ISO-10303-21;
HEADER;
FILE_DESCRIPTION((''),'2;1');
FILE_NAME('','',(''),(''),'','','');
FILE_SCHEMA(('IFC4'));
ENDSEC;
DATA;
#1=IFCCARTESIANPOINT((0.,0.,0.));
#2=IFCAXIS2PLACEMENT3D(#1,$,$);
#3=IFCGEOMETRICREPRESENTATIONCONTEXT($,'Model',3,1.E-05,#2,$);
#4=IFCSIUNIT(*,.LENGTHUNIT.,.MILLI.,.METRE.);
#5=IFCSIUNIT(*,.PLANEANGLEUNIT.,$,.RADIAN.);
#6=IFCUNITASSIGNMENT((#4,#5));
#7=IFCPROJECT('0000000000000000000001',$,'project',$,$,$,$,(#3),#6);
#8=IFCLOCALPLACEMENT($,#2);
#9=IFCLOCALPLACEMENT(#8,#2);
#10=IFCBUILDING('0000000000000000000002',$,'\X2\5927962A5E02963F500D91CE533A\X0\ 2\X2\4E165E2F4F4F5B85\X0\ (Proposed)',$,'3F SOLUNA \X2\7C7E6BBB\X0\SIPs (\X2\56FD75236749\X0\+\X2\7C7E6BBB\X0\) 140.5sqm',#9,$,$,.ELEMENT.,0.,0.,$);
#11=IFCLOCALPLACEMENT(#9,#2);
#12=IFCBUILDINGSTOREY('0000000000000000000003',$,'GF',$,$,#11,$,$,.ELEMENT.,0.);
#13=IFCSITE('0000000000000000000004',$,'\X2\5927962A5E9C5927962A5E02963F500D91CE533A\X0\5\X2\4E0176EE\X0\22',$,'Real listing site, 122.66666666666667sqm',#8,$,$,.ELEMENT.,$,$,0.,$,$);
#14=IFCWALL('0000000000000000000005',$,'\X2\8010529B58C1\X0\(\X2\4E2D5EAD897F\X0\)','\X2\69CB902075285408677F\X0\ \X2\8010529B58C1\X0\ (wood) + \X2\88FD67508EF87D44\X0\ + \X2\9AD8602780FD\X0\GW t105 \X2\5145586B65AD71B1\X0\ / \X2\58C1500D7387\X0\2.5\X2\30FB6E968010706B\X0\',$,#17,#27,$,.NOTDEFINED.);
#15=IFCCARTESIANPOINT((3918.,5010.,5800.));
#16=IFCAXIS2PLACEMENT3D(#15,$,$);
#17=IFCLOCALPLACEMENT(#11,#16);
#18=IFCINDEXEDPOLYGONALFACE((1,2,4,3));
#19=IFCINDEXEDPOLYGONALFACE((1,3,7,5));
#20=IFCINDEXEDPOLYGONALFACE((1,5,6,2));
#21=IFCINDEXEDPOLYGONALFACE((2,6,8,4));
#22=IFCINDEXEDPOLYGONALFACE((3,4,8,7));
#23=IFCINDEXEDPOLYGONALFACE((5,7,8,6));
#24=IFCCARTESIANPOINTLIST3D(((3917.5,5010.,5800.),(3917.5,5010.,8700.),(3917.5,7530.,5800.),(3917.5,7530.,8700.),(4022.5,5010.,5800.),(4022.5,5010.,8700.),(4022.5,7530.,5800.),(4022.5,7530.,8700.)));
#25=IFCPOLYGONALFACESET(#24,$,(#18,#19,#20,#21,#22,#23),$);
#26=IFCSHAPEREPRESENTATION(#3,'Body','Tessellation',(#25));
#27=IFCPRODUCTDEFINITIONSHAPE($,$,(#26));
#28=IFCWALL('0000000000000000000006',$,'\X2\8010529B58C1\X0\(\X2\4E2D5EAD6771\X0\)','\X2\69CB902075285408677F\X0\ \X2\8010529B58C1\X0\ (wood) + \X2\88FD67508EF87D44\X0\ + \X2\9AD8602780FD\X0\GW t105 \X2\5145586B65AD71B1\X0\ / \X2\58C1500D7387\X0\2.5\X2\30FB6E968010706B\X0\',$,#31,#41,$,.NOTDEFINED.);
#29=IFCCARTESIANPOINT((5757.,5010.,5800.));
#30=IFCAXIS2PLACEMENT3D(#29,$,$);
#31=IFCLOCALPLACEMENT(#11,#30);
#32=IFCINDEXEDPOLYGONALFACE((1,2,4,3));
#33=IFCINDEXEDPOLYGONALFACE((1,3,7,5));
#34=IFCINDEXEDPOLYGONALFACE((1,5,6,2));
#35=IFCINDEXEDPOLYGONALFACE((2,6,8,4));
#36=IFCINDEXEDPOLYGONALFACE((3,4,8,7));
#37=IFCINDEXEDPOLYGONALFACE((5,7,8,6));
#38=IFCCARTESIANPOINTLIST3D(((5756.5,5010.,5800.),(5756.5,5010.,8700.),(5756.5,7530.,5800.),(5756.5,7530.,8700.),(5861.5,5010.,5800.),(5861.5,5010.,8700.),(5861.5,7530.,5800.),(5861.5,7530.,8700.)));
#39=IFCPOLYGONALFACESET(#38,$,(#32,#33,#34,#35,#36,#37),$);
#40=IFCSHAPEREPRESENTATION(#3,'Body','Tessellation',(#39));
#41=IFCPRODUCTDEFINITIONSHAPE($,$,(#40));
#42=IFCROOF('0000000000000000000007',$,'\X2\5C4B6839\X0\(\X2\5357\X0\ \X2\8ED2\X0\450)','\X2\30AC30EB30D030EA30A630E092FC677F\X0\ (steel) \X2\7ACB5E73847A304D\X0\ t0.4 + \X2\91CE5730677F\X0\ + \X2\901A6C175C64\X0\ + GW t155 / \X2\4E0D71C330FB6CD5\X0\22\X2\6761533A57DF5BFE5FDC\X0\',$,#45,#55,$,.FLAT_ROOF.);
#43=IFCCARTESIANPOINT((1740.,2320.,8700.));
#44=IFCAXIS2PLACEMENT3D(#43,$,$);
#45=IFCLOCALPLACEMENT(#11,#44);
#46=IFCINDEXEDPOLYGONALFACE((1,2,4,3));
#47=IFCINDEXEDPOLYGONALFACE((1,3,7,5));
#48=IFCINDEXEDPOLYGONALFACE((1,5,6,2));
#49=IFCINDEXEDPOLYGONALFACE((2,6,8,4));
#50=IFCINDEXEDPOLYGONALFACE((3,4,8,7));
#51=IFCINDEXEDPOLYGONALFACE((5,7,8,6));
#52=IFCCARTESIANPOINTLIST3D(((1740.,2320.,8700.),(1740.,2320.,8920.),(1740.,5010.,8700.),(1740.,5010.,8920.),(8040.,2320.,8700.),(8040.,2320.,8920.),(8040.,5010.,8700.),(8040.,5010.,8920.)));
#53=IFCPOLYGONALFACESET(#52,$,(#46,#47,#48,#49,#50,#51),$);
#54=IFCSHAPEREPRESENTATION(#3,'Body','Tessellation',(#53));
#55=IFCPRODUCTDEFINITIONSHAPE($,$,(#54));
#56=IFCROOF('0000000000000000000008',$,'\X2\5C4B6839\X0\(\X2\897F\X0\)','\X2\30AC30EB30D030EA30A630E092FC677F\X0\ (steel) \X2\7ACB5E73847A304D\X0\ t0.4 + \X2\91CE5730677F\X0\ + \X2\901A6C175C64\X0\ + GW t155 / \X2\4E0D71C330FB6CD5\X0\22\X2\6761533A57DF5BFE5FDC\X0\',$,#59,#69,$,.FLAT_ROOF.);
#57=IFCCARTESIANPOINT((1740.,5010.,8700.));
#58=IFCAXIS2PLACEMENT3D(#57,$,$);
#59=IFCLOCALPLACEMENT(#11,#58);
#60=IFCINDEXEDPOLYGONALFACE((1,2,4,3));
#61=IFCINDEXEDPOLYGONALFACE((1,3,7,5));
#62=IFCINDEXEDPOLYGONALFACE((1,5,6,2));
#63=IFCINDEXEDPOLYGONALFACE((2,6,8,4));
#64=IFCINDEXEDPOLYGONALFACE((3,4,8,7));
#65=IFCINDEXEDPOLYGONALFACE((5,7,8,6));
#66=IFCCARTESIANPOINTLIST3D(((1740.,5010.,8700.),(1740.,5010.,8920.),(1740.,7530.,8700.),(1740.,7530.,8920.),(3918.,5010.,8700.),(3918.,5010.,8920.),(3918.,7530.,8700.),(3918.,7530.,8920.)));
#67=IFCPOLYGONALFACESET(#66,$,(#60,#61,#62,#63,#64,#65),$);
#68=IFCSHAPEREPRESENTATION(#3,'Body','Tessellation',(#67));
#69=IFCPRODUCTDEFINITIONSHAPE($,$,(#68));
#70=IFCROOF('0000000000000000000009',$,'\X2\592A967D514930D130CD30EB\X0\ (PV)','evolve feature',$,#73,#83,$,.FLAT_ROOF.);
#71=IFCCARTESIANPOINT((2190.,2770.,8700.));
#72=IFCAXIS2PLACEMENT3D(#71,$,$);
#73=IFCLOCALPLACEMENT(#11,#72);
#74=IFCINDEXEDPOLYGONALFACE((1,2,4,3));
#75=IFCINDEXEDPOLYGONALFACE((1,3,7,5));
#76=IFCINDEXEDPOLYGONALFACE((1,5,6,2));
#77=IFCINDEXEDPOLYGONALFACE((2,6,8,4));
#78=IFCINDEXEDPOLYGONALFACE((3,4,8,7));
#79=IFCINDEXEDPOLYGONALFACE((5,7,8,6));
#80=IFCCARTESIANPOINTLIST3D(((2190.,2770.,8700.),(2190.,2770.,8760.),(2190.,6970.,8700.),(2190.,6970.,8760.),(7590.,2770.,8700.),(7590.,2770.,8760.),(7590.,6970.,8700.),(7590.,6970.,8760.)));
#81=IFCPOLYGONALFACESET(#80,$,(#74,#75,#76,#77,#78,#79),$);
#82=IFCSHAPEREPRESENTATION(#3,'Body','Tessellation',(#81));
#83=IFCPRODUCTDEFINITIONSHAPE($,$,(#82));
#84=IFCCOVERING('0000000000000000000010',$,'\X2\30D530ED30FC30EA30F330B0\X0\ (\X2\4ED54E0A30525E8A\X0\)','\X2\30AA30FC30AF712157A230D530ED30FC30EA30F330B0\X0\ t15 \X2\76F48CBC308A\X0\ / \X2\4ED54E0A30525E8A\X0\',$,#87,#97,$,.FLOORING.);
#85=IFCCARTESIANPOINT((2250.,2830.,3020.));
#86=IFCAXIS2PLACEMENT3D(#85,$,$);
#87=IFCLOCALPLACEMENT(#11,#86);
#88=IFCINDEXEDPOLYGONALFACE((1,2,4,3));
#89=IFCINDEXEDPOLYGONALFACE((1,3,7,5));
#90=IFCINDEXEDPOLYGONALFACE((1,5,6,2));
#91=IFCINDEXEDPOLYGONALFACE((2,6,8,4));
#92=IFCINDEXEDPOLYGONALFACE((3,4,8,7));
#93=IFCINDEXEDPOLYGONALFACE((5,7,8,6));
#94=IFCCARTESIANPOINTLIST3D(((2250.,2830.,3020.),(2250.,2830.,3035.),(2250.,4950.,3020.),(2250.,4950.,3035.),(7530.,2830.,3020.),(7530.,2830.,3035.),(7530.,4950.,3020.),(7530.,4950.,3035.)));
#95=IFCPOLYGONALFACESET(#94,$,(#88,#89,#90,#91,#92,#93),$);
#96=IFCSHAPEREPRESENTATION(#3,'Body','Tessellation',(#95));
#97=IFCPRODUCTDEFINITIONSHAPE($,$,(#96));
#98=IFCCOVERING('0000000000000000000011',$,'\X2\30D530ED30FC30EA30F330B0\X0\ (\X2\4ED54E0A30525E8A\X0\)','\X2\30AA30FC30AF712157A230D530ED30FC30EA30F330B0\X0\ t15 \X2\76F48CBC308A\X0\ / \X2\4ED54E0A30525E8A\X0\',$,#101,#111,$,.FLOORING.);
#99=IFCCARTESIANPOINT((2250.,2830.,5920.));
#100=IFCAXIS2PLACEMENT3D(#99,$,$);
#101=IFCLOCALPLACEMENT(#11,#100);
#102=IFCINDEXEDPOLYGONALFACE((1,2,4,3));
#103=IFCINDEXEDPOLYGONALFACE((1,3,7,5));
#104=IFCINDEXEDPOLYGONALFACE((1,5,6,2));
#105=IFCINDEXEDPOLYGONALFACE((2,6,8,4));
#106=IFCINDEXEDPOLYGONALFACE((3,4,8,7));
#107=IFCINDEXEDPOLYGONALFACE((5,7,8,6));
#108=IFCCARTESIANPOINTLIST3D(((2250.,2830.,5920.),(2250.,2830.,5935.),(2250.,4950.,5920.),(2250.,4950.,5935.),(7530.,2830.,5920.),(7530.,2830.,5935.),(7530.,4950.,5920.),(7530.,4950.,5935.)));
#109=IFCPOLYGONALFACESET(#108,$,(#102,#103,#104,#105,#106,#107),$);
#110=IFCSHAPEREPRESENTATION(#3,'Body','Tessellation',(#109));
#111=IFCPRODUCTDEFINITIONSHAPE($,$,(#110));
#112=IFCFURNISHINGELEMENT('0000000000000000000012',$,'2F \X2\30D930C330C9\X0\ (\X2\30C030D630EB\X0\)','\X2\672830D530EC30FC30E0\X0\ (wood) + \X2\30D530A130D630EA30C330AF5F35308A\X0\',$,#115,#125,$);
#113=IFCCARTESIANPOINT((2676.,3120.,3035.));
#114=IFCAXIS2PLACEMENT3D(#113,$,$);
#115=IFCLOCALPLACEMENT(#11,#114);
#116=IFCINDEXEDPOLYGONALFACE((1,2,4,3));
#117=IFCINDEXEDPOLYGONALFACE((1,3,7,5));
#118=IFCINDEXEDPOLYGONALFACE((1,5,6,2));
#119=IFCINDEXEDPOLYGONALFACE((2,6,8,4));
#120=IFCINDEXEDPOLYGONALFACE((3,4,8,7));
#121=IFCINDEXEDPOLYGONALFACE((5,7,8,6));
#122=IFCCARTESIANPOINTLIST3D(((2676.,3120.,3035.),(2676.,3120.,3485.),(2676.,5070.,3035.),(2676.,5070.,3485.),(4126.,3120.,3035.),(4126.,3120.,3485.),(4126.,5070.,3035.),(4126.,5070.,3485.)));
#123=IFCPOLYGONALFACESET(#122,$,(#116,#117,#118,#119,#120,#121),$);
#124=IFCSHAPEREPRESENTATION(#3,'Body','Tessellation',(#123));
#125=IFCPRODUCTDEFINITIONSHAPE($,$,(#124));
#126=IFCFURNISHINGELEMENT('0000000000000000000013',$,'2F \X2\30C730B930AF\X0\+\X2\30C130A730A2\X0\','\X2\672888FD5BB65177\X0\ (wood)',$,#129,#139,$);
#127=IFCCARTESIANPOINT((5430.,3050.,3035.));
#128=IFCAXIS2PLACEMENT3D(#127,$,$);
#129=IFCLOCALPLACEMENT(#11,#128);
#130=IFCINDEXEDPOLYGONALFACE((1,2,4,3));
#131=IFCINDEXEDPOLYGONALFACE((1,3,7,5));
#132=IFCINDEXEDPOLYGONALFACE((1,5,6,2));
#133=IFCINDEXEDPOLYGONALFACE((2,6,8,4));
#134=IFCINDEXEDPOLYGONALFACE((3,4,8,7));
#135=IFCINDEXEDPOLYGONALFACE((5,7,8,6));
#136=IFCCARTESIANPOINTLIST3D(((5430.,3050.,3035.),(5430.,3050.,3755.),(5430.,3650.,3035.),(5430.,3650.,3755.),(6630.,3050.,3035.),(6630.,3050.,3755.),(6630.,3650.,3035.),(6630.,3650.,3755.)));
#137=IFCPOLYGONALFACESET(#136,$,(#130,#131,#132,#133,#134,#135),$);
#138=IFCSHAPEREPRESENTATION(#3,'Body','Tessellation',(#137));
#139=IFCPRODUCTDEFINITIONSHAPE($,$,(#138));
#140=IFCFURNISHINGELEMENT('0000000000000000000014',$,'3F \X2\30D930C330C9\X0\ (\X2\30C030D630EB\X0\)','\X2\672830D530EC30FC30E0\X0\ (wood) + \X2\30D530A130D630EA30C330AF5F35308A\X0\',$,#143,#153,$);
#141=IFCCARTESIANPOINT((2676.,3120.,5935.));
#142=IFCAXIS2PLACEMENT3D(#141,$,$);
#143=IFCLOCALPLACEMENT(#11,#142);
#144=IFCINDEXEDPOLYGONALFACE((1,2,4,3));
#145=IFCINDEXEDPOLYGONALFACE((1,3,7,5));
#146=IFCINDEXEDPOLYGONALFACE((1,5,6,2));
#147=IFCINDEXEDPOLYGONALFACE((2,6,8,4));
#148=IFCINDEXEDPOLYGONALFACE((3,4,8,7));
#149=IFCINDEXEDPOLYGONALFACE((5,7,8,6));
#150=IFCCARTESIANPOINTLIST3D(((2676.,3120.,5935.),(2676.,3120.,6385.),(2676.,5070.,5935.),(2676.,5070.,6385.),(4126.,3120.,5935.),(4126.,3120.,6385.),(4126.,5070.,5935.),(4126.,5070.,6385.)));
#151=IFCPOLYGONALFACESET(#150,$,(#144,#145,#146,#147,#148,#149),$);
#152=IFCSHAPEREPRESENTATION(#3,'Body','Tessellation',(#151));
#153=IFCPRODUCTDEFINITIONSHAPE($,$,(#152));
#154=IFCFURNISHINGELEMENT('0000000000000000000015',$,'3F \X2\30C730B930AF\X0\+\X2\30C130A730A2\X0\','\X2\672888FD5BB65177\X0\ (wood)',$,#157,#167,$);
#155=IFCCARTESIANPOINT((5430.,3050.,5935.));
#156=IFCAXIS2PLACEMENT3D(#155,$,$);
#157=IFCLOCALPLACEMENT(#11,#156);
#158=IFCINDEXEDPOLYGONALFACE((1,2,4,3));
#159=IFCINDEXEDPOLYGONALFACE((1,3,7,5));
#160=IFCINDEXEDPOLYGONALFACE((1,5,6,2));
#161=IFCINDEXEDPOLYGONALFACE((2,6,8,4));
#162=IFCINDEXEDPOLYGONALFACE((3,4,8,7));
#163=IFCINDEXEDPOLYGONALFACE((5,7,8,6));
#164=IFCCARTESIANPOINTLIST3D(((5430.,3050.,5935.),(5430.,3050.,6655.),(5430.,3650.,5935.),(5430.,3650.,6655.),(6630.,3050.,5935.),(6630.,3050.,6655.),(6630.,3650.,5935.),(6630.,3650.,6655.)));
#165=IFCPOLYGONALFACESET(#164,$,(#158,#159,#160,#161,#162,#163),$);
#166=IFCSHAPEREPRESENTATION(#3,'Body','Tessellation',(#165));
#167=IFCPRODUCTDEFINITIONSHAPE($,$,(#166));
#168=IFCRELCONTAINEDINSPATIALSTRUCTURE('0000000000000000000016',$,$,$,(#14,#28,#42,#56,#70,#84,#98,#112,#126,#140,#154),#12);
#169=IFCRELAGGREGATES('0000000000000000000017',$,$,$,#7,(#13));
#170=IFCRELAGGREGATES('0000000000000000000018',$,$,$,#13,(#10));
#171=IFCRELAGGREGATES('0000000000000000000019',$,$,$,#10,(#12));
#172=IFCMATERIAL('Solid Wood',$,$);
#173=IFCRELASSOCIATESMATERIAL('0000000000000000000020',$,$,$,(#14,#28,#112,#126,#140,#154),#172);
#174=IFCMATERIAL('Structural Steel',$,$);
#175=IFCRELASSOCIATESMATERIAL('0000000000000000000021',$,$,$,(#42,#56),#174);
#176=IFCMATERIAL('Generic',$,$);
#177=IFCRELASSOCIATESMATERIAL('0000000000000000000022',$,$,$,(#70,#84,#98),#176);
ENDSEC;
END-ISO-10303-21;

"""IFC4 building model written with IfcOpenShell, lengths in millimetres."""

from ifc_helpers import new_model, si_unit, frame, frame_2d, origin, place, context, project, spatial, rectangle, extrude, material, element, save


model = new_model("IFC4")

# Units and contexts
model_context = context("Model", 3, precision=1e-05, world=origin())
ifc_project = project(units=[si_unit("LENGTHUNIT", "METRE", prefix="MILLI"), si_unit("PLANEANGLEUNIT", "RADIAN")], contexts=[model_context])

# Site, building, storey
site_placement = place(None, origin())
site = spatial("IfcSite", under=ifc_project, at=site_placement, Name="大阪府大阪市阿倍野区5丁目22", ObjectType="Real listing site, 122.66666666666667sqm", CompositionType="ELEMENT", RefElevation=0.0)
building_placement = place(site_placement, origin())
building = spatial("IfcBuilding", under=site, at=building_placement, Name="大阪市阿倍野区 2世帯住宅 (Proposed)", ObjectType="3F SOLUNA 籾殻SIPs (国産杉+籾殻) 140.5sqm", CompositionType="ELEMENT", ElevationOfRefHeight=0.0, ElevationOfTerrain=0.0)
storey_placement = place(building_placement, origin())
storey = spatial("IfcBuildingStorey", under=building, at=storey_placement, Name="GF", CompositionType="ELEMENT", Elevation=0.0)

# Shared definitions
ifc_material_1 = material(Name="Solid Wood")

# Walls
wall_1_placement = place(storey_placement, frame((3918.0, 5010.0, 5800.0)))
element("IfcWall", 1, at=wall_1_placement, inside=storey, material=ifc_material_1, Name="耐力壁(中庭西)", Description="構造用合板 耐力壁 (wood) + 製材軸組 + 高性能GW t105 充填断熱 / 壁倍率2.5・準耐火", PredefinedType="NOTDEFINED", context=model_context, shape_type="SweptSolid", body=[
    extrude(rectangle(XDim=105.0, YDim=2520.0, at=frame_2d((52.0, 1260.0))), frame((3918.0, 5010.0, 5800.0)), (0.0, 0.0, 1.0), 2900.0),
])
wall_2_placement = place(storey_placement, frame((5757.0, 5010.0, 5800.0)))
element("IfcWall", 2, at=wall_2_placement, inside=storey, material=ifc_material_1, Name="耐力壁(中庭東)", Description="構造用合板 耐力壁 (wood) + 製材軸組 + 高性能GW t105 充填断熱 / 壁倍率2.5・準耐火", PredefinedType="NOTDEFINED", context=model_context, shape_type="SweptSolid", body=[
    extrude(rectangle(XDim=105.0, YDim=2520.0, at=frame_2d((52.0, 1260.0))), frame((5757.0, 5010.0, 5800.0)), (0.0, 0.0, 1.0), 2900.0),
])

# Roofs
ifc_material_2 = material(Name="Structural Steel")
roof_1_placement = place(storey_placement, frame((1740.0, 2320.0, 8700.0)))
element("IfcRoof", 3, at=roof_1_placement, inside=storey, material=ifc_material_2, Name="屋根(南 軒450)", Description="ガルバリウム鋼板 (steel) 立平葺き t0.4 + 野地板 + 通気層 + GW t155 / 不燃・法22条区域対応", PredefinedType="FLAT_ROOF", context=model_context, shape_type="SweptSolid", body=[
    extrude(rectangle(XDim=6300.0, YDim=2690.0, at=frame_2d((3150.0, 1345.0))), frame((1740.0, 2320.0, 8700.0)), (0.0, 0.0, 1.0), 220.0),
])
roof_2_placement = place(storey_placement, frame((1740.0, 5010.0, 8700.0)))
element("IfcRoof", 4, at=roof_2_placement, inside=storey, material=ifc_material_2, Name="屋根(西)", Description="ガルバリウム鋼板 (steel) 立平葺き t0.4 + 野地板 + 通気層 + GW t155 / 不燃・法22条区域対応", PredefinedType="FLAT_ROOF", context=model_context, shape_type="SweptSolid", body=[
    extrude(rectangle(XDim=2178.0, YDim=2520.0, at=frame_2d((1089.0, 1260.0))), frame((1740.0, 5010.0, 8700.0)), (0.0, 0.0, 1.0), 220.0),
])
ifc_material_3 = material(Name="Generic")
roof_3_placement = place(storey_placement, frame((2190.0, 2770.0, 8700.0)))
element("IfcRoof", 5, at=roof_3_placement, inside=storey, material=ifc_material_3, Name="太陽光パネル (PV)", Description="evolve feature", PredefinedType="FLAT_ROOF", context=model_context, shape_type="SweptSolid", body=[
    extrude(rectangle(XDim=5400.0, YDim=4200.0, at=frame_2d((2700.0, 2100.0))), frame((2190.0, 2770.0, 8700.0)), (0.0, 0.0, 1.0), 60.0),
])

# Coverings
covering_1_placement = place(storey_placement, frame((2250.0, 2830.0, 3020.0)))
element("IfcCovering", 6, at=covering_1_placement, inside=storey, material=ifc_material_3, Name="フローリング (仕上げ床)", Description="オーク無垢フローリング t15 直貼り / 仕上げ床", PredefinedType="FLOORING", context=model_context, shape_type="SweptSolid", body=[
    extrude(rectangle(XDim=5280.0, YDim=2120.0, at=frame_2d((2640.0, 1060.0))), frame((2250.0, 2830.0, 3020.0)), (0.0, 0.0, 1.0), 15.0),
])
covering_2_placement = place(storey_placement, frame((2250.0, 2830.0, 5920.0)))
element("IfcCovering", 7, at=covering_2_placement, inside=storey, material=ifc_material_3, Name="フローリング (仕上げ床)", Description="オーク無垢フローリング t15 直貼り / 仕上げ床", PredefinedType="FLOORING", context=model_context, shape_type="SweptSolid", body=[
    extrude(rectangle(XDim=5280.0, YDim=2120.0, at=frame_2d((2640.0, 1060.0))), frame((2250.0, 2830.0, 5920.0)), (0.0, 0.0, 1.0), 15.0),
])

# Furnishing elements
furnishing_1_placement = place(storey_placement, frame((2676.0, 3120.0, 3035.0)))
element("IfcFurnishingElement", 8, at=furnishing_1_placement, inside=storey, material=ifc_material_1, Name="2F ベッド (ダブル)", Description="木フレーム (wood) + ファブリック張り", context=model_context, shape_type="SweptSolid", body=[
    extrude(rectangle(XDim=1450.0, YDim=1950.0, at=frame_2d((725.0, 975.0))), frame((2676.0, 3120.0, 3035.0)), (0.0, 0.0, 1.0), 450.0),
])
furnishing_2_placement = place(storey_placement, frame((5430.0, 3050.0, 3035.0)))
element("IfcFurnishingElement", 9, at=furnishing_2_placement, inside=storey, material=ifc_material_1, Name="2F デスク+チェア", Description="木製家具 (wood)", context=model_context, shape_type="SweptSolid", body=[
    extrude(rectangle(XDim=1200.0, YDim=600.0, at=frame_2d((600.0, 300.0))), frame((5430.0, 3050.0, 3035.0)), (0.0, 0.0, 1.0), 720.0),
])
furnishing_3_placement = place(storey_placement, frame((2676.0, 3120.0, 5935.0)))
element("IfcFurnishingElement", 10, at=furnishing_3_placement, inside=storey, material=ifc_material_1, Name="3F ベッド (ダブル)", Description="木フレーム (wood) + ファブリック張り", context=model_context, shape_type="SweptSolid", body=[
    extrude(rectangle(XDim=1450.0, YDim=1950.0, at=frame_2d((725.0, 975.0))), frame((2676.0, 3120.0, 5935.0)), (0.0, 0.0, 1.0), 450.0),
])
furnishing_4_placement = place(storey_placement, frame((5430.0, 3050.0, 5935.0)))
element("IfcFurnishingElement", 11, at=furnishing_4_placement, inside=storey, material=ifc_material_1, Name="3F デスク+チェア", Description="木製家具 (wood)", context=model_context, shape_type="SweptSolid", body=[
    extrude(rectangle(XDim=1200.0, YDim=600.0, at=frame_2d((600.0, 300.0))), frame((5430.0, 3050.0, 5935.0)), (0.0, 0.0, 1.0), 720.0),
])

save(model, "model.ifc")
